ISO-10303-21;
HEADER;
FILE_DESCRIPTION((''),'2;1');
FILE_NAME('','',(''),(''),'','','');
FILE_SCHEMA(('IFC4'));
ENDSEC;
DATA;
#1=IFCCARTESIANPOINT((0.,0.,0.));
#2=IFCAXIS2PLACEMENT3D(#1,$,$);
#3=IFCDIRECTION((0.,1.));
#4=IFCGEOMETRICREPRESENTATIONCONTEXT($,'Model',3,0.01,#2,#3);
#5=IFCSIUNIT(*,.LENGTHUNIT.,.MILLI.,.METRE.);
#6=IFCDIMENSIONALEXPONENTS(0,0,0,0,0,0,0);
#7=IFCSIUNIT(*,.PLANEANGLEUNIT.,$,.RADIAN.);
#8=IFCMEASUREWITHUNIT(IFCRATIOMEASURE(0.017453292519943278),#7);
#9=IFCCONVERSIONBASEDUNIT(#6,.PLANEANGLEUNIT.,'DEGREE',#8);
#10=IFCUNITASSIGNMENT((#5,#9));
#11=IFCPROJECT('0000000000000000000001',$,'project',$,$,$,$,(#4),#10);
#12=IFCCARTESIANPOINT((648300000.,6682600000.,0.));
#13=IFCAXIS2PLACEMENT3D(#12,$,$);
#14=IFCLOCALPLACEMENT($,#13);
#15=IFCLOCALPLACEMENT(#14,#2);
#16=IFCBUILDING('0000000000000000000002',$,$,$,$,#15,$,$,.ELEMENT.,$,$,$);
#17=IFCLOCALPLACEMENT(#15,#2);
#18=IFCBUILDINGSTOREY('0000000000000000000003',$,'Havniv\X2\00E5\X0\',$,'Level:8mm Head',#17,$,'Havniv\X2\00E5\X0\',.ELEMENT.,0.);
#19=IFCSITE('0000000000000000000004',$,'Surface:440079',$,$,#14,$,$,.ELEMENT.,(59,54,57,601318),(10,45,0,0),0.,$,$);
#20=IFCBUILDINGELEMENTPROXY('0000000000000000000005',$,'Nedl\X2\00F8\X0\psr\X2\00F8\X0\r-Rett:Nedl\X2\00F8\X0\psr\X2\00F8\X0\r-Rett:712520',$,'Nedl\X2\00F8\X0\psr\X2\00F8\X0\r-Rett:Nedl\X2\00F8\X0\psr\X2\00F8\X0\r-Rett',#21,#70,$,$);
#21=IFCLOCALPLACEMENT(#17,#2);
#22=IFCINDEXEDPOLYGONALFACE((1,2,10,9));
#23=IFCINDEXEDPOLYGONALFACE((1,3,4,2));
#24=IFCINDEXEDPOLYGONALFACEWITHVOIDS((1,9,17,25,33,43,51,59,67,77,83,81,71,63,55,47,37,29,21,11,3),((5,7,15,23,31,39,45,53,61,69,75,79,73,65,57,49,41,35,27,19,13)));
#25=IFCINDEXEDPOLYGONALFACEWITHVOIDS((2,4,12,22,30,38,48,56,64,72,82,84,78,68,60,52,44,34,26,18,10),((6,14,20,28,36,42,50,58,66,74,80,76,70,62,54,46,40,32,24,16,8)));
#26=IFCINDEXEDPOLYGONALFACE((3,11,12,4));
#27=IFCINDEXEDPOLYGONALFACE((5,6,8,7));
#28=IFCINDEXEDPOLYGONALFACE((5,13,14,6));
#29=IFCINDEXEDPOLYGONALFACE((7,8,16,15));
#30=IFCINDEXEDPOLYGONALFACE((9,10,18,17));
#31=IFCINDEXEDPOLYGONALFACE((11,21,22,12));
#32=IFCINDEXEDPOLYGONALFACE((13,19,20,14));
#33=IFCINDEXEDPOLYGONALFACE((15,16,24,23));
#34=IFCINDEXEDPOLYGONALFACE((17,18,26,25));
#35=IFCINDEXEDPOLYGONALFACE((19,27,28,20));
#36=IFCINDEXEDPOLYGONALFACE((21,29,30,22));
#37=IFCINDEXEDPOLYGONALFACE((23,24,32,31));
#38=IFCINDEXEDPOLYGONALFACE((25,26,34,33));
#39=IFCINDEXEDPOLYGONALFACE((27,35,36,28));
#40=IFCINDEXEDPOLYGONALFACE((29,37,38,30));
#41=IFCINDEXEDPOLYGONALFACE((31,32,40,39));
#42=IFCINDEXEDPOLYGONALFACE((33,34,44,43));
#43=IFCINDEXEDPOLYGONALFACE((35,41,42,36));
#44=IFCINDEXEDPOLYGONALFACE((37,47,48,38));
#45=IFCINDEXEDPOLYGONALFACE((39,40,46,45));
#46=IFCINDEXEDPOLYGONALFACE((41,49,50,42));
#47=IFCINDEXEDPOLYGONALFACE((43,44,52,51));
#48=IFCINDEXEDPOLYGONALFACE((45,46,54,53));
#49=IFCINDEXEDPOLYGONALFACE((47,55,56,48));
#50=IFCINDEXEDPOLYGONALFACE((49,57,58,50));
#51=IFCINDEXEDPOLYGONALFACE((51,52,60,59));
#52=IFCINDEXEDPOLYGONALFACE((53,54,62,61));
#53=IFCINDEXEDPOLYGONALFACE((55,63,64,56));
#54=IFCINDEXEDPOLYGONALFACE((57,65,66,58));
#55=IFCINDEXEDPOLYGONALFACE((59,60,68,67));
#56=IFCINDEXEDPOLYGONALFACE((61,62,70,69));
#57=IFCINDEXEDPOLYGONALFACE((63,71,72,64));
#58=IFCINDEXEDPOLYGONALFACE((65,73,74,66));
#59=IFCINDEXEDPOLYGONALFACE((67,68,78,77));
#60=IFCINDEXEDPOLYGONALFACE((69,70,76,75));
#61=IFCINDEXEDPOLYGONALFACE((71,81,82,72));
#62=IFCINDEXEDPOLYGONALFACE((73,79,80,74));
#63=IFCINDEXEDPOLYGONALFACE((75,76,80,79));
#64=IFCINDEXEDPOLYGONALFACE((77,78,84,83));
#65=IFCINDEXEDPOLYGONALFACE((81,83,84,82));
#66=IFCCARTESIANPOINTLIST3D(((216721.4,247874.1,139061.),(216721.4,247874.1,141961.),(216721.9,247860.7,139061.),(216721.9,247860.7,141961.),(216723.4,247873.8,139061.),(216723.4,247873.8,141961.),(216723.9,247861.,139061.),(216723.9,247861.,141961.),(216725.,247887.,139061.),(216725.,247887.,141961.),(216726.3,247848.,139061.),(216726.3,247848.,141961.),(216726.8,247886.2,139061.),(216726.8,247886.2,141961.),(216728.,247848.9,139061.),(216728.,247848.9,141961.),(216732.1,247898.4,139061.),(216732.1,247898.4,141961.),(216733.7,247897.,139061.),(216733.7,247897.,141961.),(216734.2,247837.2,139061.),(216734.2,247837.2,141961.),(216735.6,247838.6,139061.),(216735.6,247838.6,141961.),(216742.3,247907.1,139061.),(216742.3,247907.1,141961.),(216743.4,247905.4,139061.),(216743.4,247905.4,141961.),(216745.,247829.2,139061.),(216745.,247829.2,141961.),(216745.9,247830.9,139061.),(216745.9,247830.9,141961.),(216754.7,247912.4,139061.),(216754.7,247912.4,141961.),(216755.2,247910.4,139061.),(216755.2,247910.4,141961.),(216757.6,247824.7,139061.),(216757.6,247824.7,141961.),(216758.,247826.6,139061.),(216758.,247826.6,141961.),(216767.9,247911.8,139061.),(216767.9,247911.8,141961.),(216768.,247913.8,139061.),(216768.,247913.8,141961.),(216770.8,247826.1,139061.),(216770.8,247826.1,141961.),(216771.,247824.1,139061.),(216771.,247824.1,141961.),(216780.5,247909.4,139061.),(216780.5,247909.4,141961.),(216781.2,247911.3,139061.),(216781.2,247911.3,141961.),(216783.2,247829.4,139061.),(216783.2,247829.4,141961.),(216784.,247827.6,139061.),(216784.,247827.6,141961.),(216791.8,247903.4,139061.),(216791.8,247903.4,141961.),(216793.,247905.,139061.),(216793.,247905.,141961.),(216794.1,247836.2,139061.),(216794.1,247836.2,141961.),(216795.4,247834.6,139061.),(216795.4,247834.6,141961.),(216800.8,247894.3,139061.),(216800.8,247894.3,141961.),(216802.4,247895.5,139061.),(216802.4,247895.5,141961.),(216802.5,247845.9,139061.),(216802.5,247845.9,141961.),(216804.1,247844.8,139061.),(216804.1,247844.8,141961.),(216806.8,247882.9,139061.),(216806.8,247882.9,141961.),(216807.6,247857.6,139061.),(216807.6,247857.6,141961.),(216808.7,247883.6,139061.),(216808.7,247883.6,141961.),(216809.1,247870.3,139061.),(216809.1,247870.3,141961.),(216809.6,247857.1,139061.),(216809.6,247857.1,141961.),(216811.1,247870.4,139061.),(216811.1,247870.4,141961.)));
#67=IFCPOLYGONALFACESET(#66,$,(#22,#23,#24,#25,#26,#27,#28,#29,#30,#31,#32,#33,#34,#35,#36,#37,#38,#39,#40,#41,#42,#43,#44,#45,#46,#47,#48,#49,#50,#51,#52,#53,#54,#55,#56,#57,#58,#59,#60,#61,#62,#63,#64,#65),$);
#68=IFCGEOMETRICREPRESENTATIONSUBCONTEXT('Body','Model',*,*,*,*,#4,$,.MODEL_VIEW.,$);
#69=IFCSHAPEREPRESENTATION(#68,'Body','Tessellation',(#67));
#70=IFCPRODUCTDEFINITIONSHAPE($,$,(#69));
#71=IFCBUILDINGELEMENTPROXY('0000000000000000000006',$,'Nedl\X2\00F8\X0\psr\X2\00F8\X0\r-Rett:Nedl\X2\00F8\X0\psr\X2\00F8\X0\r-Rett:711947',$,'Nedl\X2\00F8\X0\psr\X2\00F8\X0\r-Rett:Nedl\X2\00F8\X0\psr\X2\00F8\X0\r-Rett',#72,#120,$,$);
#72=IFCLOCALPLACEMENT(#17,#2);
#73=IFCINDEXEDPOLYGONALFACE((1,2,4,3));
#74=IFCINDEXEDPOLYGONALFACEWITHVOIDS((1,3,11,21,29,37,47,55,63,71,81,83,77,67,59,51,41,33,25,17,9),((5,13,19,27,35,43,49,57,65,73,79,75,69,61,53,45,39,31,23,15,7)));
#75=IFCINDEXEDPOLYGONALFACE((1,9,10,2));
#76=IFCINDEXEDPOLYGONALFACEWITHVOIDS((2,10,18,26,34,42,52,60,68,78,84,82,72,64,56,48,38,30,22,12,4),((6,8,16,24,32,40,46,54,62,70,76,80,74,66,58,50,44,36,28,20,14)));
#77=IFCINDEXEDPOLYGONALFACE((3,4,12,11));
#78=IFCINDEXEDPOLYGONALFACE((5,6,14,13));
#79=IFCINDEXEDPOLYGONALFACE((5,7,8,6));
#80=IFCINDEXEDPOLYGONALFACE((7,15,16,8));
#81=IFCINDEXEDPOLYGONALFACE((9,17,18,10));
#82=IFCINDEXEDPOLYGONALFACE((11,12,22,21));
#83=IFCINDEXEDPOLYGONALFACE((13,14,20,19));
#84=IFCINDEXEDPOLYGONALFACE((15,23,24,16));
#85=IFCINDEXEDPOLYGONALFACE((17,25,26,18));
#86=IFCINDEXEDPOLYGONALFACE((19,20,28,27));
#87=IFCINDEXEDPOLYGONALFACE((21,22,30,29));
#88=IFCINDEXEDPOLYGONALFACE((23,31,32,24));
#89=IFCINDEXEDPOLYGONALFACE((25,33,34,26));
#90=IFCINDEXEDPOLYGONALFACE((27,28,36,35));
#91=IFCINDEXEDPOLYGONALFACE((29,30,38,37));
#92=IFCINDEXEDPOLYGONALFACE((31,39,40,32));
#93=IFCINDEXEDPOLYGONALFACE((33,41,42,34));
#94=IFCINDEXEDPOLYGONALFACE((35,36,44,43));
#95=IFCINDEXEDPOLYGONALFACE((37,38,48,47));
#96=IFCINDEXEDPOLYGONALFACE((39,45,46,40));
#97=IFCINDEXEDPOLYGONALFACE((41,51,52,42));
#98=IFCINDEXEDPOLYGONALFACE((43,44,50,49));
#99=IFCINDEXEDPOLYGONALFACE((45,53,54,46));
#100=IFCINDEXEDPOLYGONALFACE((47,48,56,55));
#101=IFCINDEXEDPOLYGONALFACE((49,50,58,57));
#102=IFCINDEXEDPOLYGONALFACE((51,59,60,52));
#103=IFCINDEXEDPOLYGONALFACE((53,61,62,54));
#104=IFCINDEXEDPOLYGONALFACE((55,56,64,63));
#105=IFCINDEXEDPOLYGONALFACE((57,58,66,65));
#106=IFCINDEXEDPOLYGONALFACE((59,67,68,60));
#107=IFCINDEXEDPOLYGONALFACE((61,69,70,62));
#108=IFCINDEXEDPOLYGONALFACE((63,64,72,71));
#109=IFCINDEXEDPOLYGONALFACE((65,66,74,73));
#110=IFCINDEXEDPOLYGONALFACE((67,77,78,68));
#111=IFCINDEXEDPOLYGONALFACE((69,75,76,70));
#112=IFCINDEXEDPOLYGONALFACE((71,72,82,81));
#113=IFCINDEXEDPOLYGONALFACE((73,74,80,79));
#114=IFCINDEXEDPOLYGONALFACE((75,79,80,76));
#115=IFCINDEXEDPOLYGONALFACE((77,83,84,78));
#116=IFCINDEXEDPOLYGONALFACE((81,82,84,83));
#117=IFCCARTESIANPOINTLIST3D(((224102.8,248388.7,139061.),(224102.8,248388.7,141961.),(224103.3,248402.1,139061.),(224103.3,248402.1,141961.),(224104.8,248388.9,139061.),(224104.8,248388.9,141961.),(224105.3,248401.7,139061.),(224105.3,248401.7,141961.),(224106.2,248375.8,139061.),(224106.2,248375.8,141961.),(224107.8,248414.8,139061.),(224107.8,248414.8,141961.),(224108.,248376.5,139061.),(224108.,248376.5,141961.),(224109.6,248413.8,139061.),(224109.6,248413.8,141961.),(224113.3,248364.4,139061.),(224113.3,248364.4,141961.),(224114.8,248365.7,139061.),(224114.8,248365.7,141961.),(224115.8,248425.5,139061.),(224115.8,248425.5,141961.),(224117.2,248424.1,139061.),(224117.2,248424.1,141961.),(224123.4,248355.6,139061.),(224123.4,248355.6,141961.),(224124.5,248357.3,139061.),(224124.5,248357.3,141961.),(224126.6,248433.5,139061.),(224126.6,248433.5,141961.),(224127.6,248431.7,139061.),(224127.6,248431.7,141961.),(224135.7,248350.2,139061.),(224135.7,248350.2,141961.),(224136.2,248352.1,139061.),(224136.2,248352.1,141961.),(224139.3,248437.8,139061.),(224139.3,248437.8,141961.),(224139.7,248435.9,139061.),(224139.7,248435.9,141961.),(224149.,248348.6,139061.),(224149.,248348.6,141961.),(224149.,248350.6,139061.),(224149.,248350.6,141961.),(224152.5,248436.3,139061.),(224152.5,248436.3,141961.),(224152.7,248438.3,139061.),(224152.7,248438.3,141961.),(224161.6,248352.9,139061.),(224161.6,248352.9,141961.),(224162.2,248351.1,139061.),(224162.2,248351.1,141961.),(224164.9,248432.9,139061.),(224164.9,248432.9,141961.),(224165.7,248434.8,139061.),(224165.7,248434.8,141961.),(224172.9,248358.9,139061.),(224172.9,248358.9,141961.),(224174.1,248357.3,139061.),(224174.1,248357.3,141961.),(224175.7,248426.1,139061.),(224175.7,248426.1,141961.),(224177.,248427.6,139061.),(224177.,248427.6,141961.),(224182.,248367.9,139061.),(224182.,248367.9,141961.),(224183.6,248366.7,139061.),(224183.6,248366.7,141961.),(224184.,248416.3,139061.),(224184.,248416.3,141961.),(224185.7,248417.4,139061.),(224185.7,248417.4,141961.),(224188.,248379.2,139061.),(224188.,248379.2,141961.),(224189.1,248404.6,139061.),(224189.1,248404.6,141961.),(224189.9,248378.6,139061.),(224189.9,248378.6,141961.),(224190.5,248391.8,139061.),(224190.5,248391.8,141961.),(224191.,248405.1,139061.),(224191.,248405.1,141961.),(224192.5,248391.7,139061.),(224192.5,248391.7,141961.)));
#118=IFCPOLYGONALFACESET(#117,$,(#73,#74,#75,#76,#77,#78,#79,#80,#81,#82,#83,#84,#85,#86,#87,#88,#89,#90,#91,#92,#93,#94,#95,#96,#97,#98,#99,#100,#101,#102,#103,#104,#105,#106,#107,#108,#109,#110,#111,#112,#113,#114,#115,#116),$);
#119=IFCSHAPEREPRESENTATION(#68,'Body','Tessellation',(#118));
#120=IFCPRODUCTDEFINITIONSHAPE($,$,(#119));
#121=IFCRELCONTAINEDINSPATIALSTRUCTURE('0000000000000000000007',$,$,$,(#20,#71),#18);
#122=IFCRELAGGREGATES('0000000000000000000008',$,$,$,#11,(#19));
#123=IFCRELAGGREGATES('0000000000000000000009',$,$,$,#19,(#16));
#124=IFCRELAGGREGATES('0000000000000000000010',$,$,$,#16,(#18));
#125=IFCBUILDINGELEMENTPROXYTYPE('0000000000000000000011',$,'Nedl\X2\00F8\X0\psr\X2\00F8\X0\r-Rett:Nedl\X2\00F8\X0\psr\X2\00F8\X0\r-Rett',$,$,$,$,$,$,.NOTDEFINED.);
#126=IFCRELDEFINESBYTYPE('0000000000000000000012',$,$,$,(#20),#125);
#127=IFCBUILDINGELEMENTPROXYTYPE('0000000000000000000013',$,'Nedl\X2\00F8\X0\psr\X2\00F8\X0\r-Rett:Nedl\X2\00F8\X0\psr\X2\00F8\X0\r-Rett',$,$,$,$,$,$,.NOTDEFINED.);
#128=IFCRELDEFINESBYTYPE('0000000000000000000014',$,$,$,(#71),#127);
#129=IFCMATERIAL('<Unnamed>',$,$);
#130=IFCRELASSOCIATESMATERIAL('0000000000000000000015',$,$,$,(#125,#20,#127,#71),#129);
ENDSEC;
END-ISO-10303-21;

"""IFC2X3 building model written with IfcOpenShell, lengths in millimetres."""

from ifc_helpers import new_model, entity, si_unit, converted_unit, direction, frame, frame_2d, origin, place, context, subcontext, project, spatial, hollow_circle, extrude, source, transform, mapped, material, type_object, type_shapes, element, save


model = new_model("IFC2X3")

# Units and contexts
model_context = context("Model", 3, precision=0.01, world=origin(), true_north=direction((0.0, 1.0)))
body_context = subcontext(model_context, "Body", "Model", "MODEL_VIEW")
ifc_project = project(units=[si_unit("LENGTHUNIT", "METRE", prefix="MILLI"), converted_unit("PLANEANGLEUNIT", "DEGREE", entity("IfcRatioMeasure", 0.017453292519943278), si_unit("PLANEANGLEUNIT", "RADIAN"), dimensions=[0, 0, 0, 0, 0, 0, 0])], contexts=[model_context])

# Site, building, storey
site_placement = place(None, frame((648300000.0, 6682600000.0, 0.0)))
site = spatial("IfcSite", under=ifc_project, at=site_placement, Name="Surface:440079", CompositionType="ELEMENT", RefLatitude=(59, 54, 57, 601318), RefLongitude=(10, 45, 0, 0), RefElevation=0.0)
building_placement = place(site_placement, origin())
building = spatial("IfcBuilding", under=site, at=building_placement, CompositionType="ELEMENT")
storey_placement = place(building_placement, origin())
storey = spatial("IfcBuildingStorey", under=building, at=storey_placement, Name="Havnivå", ObjectType="Level:8mm Head", LongName="Havnivå", CompositionType="ELEMENT", Elevation=0.0)

# Building element proxies
ifc_material_1 = material(Name="<Unnamed>")
building_element_proxy_type_1 = type_object("IfcBuildingElementProxyType", Name="Nedløpsrør-Rett:Nedløpsrør-Rett", PredefinedType="NOTDEFINED", material=ifc_material_1)
shared_shape_1 = source(origin(), body_context, "Body", "SweptSolid", [
    extrude(hollow_circle(Radius=45.0, WallThickness=2.0, at=frame_2d((0.0, 0.0), x_axis=(1.0, 0.0))), frame((0.0, 0.0, 0.0), z_axis=(0.0, 0.0, 1.0), x_axis=(-1.0, 0.0, 0.0)), (0.0, 0.0, 1.0), 2900.0),
])
type_shapes(building_element_proxy_type_1, [shared_shape_1])
for number, where, z_axis, x_axis, name in (
    (1, (216766.1, 247868.9, 139061.0), (0.0, 0.0, 1.0), (0.755467, -0.655187, 0.0), "Nedløpsrør-Rett:Nedløpsrør-Rett:712520"),
):
    element("IfcBuildingElementProxy", number, at=place(storey_placement, frame(where, z_axis=z_axis, x_axis=x_axis)), inside=storey, type_object=building_element_proxy_type_1, material=ifc_material_1, Name=name, ObjectType="Nedløpsrør-Rett:Nedløpsrør-Rett", context=body_context, shape_type="MappedRepresentation", body=[
        mapped(shared_shape_1, transform((0.0, 0.0, 0.0), scale=1.0)),
    ])
building_element_proxy_type_2 = type_object("IfcBuildingElementProxyType", Name="Nedløpsrør-Rett:Nedløpsrør-Rett", PredefinedType="NOTDEFINED", material=ifc_material_1)
shared_shape_2 = source(origin(), body_context, "Body", "SweptSolid", [
    extrude(hollow_circle(Radius=45.0, WallThickness=2.0, at=frame_2d((0.0, 0.0), x_axis=(1.0, 0.0))), frame((0.0, 0.0, 0.0), z_axis=(0.0, 0.0, 1.0), x_axis=(-1.0, 0.0, 0.0)), (0.0, 0.0, 1.0), 2900.0),
])
type_shapes(building_element_proxy_type_2, [shared_shape_2])
proxy_placement = place(storey_placement, frame((224147.5, 248393.6, 139061.0), z_axis=(0.0, 0.0, 1.0), x_axis=(-0.655187, -0.755467, 0.0)))
element("IfcBuildingElementProxy", 2, at=proxy_placement, inside=storey, type_object=building_element_proxy_type_2, material=ifc_material_1, Name="Nedløpsrør-Rett:Nedløpsrør-Rett:711947", ObjectType="Nedløpsrør-Rett:Nedløpsrør-Rett", context=body_context, shape_type="MappedRepresentation", body=[
    mapped(shared_shape_2, transform((0.0, 0.0, 0.0), scale=1.0)),
])

save(model, "model.ifc")
